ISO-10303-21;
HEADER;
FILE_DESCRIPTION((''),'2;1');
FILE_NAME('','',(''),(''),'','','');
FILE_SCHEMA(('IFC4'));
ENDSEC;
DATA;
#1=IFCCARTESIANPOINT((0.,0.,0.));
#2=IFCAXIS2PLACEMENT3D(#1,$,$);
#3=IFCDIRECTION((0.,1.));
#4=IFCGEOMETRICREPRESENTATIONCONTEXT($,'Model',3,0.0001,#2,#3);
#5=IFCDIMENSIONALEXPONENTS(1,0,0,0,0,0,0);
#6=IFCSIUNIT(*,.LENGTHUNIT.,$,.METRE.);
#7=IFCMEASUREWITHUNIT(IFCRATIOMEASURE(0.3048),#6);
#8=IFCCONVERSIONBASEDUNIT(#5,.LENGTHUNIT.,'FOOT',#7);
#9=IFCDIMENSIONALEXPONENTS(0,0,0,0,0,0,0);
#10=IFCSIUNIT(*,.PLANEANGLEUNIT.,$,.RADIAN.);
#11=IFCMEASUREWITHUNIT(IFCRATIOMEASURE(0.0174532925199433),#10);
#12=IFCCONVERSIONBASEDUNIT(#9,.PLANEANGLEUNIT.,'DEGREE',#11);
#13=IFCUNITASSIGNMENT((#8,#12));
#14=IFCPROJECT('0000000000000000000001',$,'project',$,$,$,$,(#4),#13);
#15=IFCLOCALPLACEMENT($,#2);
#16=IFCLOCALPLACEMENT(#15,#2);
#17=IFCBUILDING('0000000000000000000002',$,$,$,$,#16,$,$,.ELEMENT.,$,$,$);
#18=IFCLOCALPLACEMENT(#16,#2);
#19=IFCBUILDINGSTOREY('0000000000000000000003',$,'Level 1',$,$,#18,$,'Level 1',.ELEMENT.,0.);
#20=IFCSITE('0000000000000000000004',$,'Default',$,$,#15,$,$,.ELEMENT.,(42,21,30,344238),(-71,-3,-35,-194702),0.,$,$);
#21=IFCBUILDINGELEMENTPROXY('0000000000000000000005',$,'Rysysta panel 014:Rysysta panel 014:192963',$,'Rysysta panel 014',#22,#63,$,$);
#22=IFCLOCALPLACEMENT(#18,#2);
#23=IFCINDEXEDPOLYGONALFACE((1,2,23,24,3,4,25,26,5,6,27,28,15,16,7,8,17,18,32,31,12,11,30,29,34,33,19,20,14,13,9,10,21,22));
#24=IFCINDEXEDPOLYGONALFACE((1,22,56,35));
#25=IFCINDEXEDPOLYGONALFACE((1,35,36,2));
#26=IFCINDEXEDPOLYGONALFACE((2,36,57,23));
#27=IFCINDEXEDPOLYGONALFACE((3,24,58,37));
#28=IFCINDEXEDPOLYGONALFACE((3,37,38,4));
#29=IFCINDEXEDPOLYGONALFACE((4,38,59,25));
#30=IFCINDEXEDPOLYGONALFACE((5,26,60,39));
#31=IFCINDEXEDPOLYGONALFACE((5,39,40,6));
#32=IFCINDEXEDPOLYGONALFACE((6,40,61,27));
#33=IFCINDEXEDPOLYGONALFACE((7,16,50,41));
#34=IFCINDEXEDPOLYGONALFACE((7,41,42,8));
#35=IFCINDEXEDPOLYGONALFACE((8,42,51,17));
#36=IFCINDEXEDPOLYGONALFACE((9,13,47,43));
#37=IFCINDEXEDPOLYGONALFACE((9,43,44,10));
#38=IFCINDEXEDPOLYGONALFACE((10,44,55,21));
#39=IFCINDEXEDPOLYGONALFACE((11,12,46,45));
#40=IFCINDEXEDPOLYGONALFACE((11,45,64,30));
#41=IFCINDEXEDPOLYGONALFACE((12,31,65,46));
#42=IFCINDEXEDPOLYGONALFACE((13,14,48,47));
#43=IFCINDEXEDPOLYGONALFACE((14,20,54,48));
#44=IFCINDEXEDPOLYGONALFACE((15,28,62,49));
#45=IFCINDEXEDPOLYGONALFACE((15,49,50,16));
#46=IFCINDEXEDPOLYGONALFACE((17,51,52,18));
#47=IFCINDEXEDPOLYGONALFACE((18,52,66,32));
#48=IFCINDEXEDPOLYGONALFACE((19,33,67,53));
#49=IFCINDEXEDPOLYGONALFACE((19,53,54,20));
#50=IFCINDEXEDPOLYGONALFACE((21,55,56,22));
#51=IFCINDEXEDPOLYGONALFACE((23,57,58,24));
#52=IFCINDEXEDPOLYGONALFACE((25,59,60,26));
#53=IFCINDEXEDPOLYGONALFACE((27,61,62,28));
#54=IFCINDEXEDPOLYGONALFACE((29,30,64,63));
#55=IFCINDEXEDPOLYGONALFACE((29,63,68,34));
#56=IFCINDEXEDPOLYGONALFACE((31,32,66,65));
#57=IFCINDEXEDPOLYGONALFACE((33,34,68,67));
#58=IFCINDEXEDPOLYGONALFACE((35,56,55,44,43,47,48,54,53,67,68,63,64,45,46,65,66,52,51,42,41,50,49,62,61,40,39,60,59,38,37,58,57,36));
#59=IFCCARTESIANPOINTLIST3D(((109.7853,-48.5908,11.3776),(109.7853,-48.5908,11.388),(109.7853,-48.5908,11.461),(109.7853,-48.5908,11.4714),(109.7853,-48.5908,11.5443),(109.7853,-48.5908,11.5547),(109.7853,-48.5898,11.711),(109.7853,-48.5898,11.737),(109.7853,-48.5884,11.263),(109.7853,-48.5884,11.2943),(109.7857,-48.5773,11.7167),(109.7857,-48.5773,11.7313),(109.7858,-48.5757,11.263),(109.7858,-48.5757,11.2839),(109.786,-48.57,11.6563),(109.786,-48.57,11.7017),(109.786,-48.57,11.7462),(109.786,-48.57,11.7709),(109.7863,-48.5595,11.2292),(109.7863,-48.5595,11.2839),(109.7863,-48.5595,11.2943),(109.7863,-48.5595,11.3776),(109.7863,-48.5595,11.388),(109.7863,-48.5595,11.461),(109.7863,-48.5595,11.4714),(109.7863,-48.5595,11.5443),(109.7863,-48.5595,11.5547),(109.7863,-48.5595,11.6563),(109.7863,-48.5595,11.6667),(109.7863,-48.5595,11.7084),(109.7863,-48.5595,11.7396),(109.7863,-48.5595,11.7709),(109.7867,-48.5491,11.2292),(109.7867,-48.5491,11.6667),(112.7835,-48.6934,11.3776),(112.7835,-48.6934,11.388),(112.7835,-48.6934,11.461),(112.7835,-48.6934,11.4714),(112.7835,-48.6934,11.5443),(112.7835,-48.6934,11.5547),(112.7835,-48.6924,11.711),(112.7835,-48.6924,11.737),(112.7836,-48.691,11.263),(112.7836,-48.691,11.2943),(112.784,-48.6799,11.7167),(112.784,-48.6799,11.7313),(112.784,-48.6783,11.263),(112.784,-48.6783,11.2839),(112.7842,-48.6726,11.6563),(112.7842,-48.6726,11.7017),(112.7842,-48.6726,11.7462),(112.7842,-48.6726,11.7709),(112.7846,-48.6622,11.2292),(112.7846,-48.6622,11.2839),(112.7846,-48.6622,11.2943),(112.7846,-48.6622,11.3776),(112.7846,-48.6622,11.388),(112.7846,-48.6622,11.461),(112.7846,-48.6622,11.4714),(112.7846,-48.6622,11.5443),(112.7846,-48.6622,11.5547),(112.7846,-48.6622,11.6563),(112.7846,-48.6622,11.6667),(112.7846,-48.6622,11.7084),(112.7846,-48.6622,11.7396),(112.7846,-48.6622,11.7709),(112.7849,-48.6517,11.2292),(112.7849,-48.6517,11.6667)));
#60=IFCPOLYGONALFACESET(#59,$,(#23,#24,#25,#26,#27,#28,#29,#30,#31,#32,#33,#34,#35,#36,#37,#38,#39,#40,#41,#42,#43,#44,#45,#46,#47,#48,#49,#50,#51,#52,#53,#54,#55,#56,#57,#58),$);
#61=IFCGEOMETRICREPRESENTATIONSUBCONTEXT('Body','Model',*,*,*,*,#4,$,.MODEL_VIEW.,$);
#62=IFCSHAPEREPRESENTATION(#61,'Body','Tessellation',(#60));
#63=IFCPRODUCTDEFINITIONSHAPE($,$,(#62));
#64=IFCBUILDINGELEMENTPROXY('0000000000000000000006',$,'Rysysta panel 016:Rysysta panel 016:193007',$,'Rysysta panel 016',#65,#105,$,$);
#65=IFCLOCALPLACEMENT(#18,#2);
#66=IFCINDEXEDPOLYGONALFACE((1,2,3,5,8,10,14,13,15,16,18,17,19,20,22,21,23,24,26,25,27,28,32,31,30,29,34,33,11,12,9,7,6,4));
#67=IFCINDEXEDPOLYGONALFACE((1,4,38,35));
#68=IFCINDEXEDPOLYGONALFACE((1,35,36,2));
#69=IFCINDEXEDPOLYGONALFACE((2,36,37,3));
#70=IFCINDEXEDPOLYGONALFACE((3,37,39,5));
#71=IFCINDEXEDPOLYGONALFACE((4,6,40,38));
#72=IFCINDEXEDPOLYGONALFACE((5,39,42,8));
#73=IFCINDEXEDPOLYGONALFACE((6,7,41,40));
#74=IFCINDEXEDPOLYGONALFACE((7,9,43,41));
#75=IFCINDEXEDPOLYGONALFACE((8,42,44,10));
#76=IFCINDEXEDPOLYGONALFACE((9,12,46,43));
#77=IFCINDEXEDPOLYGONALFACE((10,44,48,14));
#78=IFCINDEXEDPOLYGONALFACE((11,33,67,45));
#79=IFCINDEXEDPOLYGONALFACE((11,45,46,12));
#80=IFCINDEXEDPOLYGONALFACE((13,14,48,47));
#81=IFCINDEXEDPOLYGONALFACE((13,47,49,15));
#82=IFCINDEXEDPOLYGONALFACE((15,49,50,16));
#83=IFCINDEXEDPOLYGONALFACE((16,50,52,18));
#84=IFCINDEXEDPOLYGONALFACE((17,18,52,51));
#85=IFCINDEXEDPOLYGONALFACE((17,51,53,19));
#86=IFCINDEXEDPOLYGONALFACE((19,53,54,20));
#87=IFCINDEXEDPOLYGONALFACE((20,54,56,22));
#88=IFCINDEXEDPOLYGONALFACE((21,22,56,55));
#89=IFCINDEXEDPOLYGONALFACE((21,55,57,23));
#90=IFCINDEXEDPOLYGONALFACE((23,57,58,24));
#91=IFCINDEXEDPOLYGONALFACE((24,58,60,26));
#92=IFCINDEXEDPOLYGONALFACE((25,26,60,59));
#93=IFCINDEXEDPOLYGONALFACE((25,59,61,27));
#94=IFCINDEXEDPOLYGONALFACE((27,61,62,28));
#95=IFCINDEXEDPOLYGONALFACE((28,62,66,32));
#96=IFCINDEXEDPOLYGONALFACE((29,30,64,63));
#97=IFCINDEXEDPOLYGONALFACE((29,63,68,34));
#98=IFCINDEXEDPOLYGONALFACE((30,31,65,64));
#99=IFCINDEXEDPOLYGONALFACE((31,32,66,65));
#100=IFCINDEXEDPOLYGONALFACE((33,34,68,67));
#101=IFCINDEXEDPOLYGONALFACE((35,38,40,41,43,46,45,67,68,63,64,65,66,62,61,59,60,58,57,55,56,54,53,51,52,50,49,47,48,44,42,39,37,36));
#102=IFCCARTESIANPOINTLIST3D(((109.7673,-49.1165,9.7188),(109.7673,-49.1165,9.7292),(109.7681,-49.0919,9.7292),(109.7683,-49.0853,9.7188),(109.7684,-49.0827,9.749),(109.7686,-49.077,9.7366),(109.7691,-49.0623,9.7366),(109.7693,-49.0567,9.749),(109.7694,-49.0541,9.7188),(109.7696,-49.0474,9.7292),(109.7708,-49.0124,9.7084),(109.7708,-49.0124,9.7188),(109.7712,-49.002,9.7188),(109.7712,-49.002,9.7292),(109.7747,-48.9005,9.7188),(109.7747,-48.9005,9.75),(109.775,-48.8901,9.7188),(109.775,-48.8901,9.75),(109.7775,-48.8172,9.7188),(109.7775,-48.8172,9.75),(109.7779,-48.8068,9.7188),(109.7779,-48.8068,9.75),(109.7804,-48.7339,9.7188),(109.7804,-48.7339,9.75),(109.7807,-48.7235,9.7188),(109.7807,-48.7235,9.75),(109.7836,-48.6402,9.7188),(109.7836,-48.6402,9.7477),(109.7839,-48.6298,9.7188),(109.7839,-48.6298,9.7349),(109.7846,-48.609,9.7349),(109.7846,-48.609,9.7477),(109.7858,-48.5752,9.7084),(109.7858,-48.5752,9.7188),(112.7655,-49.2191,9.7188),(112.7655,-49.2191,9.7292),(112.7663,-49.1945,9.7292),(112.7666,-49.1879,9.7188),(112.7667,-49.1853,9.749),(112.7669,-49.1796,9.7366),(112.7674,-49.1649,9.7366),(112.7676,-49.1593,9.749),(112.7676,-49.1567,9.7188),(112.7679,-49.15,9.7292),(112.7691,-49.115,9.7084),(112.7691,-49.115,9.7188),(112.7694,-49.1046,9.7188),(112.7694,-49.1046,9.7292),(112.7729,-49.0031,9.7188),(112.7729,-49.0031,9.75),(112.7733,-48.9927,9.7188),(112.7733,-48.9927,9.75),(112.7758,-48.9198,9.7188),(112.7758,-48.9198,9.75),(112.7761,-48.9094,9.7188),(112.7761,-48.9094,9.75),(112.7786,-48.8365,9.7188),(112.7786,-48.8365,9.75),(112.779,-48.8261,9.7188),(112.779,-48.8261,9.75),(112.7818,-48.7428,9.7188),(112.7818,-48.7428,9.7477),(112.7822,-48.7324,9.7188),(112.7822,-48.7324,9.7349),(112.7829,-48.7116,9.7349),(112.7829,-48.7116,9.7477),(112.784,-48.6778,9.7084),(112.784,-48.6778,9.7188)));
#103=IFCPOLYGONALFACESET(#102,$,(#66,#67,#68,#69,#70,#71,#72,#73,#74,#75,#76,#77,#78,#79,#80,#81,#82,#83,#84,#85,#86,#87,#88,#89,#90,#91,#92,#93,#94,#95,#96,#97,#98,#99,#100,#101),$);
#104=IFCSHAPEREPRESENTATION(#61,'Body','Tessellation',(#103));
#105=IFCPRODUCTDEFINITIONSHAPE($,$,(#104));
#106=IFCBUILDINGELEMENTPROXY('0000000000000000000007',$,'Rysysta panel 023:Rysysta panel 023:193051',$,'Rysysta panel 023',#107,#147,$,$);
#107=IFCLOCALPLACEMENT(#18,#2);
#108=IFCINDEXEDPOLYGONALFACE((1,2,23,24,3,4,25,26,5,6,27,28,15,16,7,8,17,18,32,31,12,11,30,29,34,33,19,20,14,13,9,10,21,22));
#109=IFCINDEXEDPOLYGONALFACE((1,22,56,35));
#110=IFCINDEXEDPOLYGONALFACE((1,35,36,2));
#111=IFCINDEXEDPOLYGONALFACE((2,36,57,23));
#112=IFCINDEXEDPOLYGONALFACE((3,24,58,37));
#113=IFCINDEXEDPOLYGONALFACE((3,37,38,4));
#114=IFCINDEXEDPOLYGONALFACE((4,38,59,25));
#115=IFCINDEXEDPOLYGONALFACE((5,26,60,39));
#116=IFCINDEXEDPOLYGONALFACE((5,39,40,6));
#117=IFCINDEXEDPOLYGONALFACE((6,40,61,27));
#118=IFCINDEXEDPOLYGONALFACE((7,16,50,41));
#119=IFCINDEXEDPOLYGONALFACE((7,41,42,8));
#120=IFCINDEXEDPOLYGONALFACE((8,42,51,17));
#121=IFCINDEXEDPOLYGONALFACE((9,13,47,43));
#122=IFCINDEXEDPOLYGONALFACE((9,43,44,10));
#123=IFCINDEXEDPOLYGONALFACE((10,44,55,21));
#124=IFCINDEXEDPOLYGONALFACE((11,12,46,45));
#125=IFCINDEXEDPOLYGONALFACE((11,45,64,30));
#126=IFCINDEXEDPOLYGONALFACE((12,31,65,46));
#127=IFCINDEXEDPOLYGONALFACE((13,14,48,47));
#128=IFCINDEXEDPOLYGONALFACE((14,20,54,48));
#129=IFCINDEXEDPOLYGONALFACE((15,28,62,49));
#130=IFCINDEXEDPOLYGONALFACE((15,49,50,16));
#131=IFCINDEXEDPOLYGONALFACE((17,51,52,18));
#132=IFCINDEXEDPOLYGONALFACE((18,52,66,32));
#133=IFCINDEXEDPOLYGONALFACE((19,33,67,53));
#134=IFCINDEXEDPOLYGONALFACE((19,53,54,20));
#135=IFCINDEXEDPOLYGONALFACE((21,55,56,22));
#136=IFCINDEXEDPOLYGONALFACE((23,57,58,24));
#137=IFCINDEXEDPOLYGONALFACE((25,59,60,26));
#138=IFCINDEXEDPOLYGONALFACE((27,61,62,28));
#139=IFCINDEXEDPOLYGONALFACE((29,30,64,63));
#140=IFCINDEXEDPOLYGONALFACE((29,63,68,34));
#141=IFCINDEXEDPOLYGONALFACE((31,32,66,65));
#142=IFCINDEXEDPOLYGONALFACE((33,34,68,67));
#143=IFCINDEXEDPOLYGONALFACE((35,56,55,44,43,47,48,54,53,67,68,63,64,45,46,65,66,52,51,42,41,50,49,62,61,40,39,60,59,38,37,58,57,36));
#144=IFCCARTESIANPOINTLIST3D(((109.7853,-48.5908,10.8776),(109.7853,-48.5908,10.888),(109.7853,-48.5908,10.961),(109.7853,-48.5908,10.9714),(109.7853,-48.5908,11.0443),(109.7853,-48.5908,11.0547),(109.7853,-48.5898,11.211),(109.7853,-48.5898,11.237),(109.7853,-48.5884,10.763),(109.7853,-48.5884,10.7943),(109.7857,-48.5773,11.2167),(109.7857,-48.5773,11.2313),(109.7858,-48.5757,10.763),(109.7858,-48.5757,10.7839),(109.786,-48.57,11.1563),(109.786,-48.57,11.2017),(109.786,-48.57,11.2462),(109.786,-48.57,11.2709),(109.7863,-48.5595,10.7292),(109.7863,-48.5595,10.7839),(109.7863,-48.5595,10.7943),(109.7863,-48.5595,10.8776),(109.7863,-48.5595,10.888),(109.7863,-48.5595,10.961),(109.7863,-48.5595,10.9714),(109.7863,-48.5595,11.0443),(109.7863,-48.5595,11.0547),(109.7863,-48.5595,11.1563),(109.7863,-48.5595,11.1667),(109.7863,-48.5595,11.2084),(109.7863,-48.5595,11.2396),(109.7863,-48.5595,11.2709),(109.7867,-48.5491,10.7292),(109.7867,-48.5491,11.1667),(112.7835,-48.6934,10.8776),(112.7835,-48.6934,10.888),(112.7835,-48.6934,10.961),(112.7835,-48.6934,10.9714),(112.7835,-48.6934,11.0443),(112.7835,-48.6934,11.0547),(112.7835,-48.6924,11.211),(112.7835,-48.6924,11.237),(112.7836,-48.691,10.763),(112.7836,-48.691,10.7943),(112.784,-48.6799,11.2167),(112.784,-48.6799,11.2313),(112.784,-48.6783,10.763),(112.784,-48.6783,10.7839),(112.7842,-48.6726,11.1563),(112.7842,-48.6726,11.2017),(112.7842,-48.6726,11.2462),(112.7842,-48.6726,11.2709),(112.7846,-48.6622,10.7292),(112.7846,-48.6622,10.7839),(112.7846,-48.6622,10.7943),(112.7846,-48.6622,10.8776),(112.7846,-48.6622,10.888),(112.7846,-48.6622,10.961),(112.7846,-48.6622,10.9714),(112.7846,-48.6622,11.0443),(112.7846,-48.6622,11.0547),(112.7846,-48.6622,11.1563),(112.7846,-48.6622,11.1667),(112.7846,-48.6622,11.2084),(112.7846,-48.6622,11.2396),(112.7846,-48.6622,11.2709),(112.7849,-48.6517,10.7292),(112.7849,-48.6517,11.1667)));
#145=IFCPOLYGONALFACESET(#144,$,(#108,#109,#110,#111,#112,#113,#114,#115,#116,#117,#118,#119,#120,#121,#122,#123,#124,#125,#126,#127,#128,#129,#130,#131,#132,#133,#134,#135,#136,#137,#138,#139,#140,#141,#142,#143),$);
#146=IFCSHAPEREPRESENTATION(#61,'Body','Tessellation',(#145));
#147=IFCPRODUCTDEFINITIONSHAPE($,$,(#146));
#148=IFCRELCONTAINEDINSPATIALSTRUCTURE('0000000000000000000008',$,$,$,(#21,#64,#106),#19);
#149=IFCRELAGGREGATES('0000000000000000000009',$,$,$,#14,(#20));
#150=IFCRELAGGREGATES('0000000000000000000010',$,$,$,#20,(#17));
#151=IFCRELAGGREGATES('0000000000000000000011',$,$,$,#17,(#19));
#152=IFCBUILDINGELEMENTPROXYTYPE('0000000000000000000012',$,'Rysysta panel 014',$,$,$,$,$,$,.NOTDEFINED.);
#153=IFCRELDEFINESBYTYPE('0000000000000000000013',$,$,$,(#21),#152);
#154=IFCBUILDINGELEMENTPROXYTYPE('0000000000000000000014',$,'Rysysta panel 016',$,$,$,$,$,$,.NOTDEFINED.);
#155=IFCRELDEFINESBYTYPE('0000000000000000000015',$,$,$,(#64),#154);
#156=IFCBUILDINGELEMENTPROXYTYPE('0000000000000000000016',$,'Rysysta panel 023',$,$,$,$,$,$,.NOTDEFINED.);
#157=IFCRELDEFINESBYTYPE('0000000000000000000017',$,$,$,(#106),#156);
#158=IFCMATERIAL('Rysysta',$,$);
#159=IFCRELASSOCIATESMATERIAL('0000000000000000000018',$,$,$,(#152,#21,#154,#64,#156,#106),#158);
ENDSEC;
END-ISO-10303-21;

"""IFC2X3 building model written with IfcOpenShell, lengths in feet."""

from ifc_helpers import new_model, entity, si_unit, converted_unit, direction, frame, origin, place, context, subcontext, project, spatial, polyline, outline, extrude, source, transform, mapped, material, type_object, type_shapes, element, save


model = new_model("IFC2X3")

# Units and contexts
model_context = context("Model", 3, precision=0.0001, world=origin(), true_north=direction((0.0, 1.0)))
body_context = subcontext(model_context, "Body", "Model", "MODEL_VIEW")
ifc_project = project(units=[converted_unit("LENGTHUNIT", "FOOT", entity("IfcRatioMeasure", 0.3048), si_unit("LENGTHUNIT", "METRE"), dimensions=[1, 0, 0, 0, 0, 0, 0]), converted_unit("PLANEANGLEUNIT", "DEGREE", entity("IfcRatioMeasure", 0.0174532925199433), si_unit("PLANEANGLEUNIT", "RADIAN"), dimensions=[0, 0, 0, 0, 0, 0, 0])], contexts=[model_context])

# Site, building, storey
site_placement = place(None, origin())
site = spatial("IfcSite", under=ifc_project, at=site_placement, Name="Default", CompositionType="ELEMENT", RefLatitude=(42, 21, 30, 344238), RefLongitude=(-71, -3, -35, -194702), RefElevation=0.0)
building_placement = place(site_placement, origin())
building = spatial("IfcBuilding", under=site, at=building_placement, CompositionType="ELEMENT")
storey_placement = place(building_placement, origin())
storey = spatial("IfcBuildingStorey", under=building, at=storey_placement, Name="Level 1", LongName="Level 1", CompositionType="ELEMENT", Elevation=0.0)

# Building element proxies
ifc_material_1 = material(Name="Rysysta")
building_element_proxy_type_1 = type_object("IfcBuildingElementProxyType", Name="Rysysta panel 014", PredefinedType="NOTDEFINED", material=ifc_material_1)
shared_shape_1 = source(origin(), body_context, "Body", "SweptSolid", [
    extrude(outline(polyline([(-0.022, 0.1457), (-0.022, -0.2918), (-0.0116, -0.2918), (-0.0116, -0.2371), (0.0045, -0.2371), (0.0045, -0.258), (0.0173, -0.258), (0.0173, -0.2267), (-0.0116, -0.2267), (-0.0116, -0.1434), (0.0196, -0.1434), (0.0196, -0.133), (-0.0116, -0.133), (-0.0116, -0.06), (0.0196, -0.06), (0.0196, -0.0496), (-0.0116, -0.0496), (-0.0116, 0.0233), (0.0196, 0.0233), (0.0196, 0.0337), (-0.0116, 0.0337), (-0.0116, 0.1353), (-0.0012, 0.1353), (-0.0012, 0.1807), (0.0186, 0.1899), (0.0186, 0.216), (-0.0012, 0.2252), (-0.0012, 0.2498), (-0.0116, 0.2498), (-0.0116, 0.2186), (0.0062, 0.2103), (0.0062, 0.1956), (-0.0116, 0.1873), (-0.0116, 0.1457), (-0.022, 0.1457)])), frame((109.7859, -48.5711, 11.521), z_axis=(-0.999415, 0.034202, 0.0), x_axis=(-0.034202, -0.999415, 0.0)), (0.0, 0.0, -1.0), 3.0),
])
type_shapes(building_element_proxy_type_1, [shared_shape_1])
proxy_1_placement = place(storey_placement, origin())
element("IfcBuildingElementProxy", 1, at=proxy_1_placement, inside=storey, type_object=building_element_proxy_type_1, material=ifc_material_1, Name="Rysysta panel 014:Rysysta panel 014:192963", ObjectType="Rysysta panel 014", context=body_context, shape_type="MappedRepresentation", body=[
    mapped(shared_shape_1, transform((0.0, 0.0, 0.0), scale=1.0)),
])
building_element_proxy_type_2 = type_object("IfcBuildingElementProxyType", Name="Rysysta panel 016", PredefinedType="NOTDEFINED", material=ifc_material_1)
shared_shape_2 = source(origin(), body_context, "Body", "SweptSolid", [
    extrude(outline(polyline([(-0.2918, -0.0116), (-0.2918, -0.022), (0.1457, -0.022), (0.1457, -0.0116), (0.1873, -0.0116), (0.1956, 0.0062), (0.2103, 0.0062), (0.2186, -0.0116), (0.2498, -0.0116), (0.2498, -0.0012), (0.2252, -0.0012), (0.216, 0.0186), (0.1899, 0.0186), (0.1807, -0.0012), (0.1353, -0.0012), (0.1353, -0.0116), (0.0337, -0.0116), (0.0337, 0.0196), (0.0233, 0.0196), (0.0233, -0.0116), (-0.0496, -0.0116), (-0.0496, 0.0196), (-0.06, 0.0196), (-0.06, -0.0116), (-0.133, -0.0116), (-0.133, 0.0196), (-0.1434, 0.0196), (-0.1434, -0.0116), (-0.2267, -0.0116), (-0.2267, 0.0173), (-0.258, 0.0173), (-0.258, 0.0045), (-0.2371, 0.0045), (-0.2371, -0.0116), (-0.2918, -0.0116)])), frame((109.7758, -48.8668, 9.7304), z_axis=(-0.999415, 0.034202, 0.0), x_axis=(-0.034202, -0.999415, 0.0)), (0.0, 0.0, -1.0), 3.0),
])
type_shapes(building_element_proxy_type_2, [shared_shape_2])
proxy_2_placement = place(storey_placement, origin())
element("IfcBuildingElementProxy", 2, at=proxy_2_placement, inside=storey, type_object=building_element_proxy_type_2, material=ifc_material_1, Name="Rysysta panel 016:Rysysta panel 016:193007", ObjectType="Rysysta panel 016", context=body_context, shape_type="MappedRepresentation", body=[
    mapped(shared_shape_2, transform((0.0, 0.0, 0.0), scale=1.0)),
])
building_element_proxy_type_3 = type_object("IfcBuildingElementProxyType", Name="Rysysta panel 023", PredefinedType="NOTDEFINED", material=ifc_material_1)
shared_shape_3 = source(origin(), body_context, "Body", "SweptSolid", [
    extrude(outline(polyline([(-0.022, 0.1457), (-0.022, -0.2918), (-0.0116, -0.2918), (-0.0116, -0.2371), (0.0045, -0.2371), (0.0045, -0.258), (0.0173, -0.258), (0.0173, -0.2267), (-0.0116, -0.2267), (-0.0116, -0.1434), (0.0196, -0.1434), (0.0196, -0.133), (-0.0116, -0.133), (-0.0116, -0.06), (0.0196, -0.06), (0.0196, -0.0496), (-0.0116, -0.0496), (-0.0116, 0.0233), (0.0196, 0.0233), (0.0196, 0.0337), (-0.0116, 0.0337), (-0.0116, 0.1353), (-0.0012, 0.1353), (-0.0012, 0.1807), (0.0186, 0.1899), (0.0186, 0.216), (-0.0012, 0.2252), (-0.0012, 0.2498), (-0.0116, 0.2498), (-0.0116, 0.2186), (0.0062, 0.2103), (0.0062, 0.1956), (-0.0116, 0.1873), (-0.0116, 0.1457), (-0.022, 0.1457)])), frame((109.7859, -48.5711, 11.021), z_axis=(-0.999415, 0.034202, 0.0), x_axis=(-0.034202, -0.999415, 0.0)), (0.0, 0.0, -1.0), 3.0),
])
type_shapes(building_element_proxy_type_3, [shared_shape_3])
proxy_3_placement = place(storey_placement, origin())
element("IfcBuildingElementProxy", 3, at=proxy_3_placement, inside=storey, type_object=building_element_proxy_type_3, material=ifc_material_1, Name="Rysysta panel 023:Rysysta panel 023:193051", ObjectType="Rysysta panel 023", context=body_context, shape_type="MappedRepresentation", body=[
    mapped(shared_shape_3, transform((0.0, 0.0, 0.0), scale=1.0)),
])

save(model, "model.ifc")
